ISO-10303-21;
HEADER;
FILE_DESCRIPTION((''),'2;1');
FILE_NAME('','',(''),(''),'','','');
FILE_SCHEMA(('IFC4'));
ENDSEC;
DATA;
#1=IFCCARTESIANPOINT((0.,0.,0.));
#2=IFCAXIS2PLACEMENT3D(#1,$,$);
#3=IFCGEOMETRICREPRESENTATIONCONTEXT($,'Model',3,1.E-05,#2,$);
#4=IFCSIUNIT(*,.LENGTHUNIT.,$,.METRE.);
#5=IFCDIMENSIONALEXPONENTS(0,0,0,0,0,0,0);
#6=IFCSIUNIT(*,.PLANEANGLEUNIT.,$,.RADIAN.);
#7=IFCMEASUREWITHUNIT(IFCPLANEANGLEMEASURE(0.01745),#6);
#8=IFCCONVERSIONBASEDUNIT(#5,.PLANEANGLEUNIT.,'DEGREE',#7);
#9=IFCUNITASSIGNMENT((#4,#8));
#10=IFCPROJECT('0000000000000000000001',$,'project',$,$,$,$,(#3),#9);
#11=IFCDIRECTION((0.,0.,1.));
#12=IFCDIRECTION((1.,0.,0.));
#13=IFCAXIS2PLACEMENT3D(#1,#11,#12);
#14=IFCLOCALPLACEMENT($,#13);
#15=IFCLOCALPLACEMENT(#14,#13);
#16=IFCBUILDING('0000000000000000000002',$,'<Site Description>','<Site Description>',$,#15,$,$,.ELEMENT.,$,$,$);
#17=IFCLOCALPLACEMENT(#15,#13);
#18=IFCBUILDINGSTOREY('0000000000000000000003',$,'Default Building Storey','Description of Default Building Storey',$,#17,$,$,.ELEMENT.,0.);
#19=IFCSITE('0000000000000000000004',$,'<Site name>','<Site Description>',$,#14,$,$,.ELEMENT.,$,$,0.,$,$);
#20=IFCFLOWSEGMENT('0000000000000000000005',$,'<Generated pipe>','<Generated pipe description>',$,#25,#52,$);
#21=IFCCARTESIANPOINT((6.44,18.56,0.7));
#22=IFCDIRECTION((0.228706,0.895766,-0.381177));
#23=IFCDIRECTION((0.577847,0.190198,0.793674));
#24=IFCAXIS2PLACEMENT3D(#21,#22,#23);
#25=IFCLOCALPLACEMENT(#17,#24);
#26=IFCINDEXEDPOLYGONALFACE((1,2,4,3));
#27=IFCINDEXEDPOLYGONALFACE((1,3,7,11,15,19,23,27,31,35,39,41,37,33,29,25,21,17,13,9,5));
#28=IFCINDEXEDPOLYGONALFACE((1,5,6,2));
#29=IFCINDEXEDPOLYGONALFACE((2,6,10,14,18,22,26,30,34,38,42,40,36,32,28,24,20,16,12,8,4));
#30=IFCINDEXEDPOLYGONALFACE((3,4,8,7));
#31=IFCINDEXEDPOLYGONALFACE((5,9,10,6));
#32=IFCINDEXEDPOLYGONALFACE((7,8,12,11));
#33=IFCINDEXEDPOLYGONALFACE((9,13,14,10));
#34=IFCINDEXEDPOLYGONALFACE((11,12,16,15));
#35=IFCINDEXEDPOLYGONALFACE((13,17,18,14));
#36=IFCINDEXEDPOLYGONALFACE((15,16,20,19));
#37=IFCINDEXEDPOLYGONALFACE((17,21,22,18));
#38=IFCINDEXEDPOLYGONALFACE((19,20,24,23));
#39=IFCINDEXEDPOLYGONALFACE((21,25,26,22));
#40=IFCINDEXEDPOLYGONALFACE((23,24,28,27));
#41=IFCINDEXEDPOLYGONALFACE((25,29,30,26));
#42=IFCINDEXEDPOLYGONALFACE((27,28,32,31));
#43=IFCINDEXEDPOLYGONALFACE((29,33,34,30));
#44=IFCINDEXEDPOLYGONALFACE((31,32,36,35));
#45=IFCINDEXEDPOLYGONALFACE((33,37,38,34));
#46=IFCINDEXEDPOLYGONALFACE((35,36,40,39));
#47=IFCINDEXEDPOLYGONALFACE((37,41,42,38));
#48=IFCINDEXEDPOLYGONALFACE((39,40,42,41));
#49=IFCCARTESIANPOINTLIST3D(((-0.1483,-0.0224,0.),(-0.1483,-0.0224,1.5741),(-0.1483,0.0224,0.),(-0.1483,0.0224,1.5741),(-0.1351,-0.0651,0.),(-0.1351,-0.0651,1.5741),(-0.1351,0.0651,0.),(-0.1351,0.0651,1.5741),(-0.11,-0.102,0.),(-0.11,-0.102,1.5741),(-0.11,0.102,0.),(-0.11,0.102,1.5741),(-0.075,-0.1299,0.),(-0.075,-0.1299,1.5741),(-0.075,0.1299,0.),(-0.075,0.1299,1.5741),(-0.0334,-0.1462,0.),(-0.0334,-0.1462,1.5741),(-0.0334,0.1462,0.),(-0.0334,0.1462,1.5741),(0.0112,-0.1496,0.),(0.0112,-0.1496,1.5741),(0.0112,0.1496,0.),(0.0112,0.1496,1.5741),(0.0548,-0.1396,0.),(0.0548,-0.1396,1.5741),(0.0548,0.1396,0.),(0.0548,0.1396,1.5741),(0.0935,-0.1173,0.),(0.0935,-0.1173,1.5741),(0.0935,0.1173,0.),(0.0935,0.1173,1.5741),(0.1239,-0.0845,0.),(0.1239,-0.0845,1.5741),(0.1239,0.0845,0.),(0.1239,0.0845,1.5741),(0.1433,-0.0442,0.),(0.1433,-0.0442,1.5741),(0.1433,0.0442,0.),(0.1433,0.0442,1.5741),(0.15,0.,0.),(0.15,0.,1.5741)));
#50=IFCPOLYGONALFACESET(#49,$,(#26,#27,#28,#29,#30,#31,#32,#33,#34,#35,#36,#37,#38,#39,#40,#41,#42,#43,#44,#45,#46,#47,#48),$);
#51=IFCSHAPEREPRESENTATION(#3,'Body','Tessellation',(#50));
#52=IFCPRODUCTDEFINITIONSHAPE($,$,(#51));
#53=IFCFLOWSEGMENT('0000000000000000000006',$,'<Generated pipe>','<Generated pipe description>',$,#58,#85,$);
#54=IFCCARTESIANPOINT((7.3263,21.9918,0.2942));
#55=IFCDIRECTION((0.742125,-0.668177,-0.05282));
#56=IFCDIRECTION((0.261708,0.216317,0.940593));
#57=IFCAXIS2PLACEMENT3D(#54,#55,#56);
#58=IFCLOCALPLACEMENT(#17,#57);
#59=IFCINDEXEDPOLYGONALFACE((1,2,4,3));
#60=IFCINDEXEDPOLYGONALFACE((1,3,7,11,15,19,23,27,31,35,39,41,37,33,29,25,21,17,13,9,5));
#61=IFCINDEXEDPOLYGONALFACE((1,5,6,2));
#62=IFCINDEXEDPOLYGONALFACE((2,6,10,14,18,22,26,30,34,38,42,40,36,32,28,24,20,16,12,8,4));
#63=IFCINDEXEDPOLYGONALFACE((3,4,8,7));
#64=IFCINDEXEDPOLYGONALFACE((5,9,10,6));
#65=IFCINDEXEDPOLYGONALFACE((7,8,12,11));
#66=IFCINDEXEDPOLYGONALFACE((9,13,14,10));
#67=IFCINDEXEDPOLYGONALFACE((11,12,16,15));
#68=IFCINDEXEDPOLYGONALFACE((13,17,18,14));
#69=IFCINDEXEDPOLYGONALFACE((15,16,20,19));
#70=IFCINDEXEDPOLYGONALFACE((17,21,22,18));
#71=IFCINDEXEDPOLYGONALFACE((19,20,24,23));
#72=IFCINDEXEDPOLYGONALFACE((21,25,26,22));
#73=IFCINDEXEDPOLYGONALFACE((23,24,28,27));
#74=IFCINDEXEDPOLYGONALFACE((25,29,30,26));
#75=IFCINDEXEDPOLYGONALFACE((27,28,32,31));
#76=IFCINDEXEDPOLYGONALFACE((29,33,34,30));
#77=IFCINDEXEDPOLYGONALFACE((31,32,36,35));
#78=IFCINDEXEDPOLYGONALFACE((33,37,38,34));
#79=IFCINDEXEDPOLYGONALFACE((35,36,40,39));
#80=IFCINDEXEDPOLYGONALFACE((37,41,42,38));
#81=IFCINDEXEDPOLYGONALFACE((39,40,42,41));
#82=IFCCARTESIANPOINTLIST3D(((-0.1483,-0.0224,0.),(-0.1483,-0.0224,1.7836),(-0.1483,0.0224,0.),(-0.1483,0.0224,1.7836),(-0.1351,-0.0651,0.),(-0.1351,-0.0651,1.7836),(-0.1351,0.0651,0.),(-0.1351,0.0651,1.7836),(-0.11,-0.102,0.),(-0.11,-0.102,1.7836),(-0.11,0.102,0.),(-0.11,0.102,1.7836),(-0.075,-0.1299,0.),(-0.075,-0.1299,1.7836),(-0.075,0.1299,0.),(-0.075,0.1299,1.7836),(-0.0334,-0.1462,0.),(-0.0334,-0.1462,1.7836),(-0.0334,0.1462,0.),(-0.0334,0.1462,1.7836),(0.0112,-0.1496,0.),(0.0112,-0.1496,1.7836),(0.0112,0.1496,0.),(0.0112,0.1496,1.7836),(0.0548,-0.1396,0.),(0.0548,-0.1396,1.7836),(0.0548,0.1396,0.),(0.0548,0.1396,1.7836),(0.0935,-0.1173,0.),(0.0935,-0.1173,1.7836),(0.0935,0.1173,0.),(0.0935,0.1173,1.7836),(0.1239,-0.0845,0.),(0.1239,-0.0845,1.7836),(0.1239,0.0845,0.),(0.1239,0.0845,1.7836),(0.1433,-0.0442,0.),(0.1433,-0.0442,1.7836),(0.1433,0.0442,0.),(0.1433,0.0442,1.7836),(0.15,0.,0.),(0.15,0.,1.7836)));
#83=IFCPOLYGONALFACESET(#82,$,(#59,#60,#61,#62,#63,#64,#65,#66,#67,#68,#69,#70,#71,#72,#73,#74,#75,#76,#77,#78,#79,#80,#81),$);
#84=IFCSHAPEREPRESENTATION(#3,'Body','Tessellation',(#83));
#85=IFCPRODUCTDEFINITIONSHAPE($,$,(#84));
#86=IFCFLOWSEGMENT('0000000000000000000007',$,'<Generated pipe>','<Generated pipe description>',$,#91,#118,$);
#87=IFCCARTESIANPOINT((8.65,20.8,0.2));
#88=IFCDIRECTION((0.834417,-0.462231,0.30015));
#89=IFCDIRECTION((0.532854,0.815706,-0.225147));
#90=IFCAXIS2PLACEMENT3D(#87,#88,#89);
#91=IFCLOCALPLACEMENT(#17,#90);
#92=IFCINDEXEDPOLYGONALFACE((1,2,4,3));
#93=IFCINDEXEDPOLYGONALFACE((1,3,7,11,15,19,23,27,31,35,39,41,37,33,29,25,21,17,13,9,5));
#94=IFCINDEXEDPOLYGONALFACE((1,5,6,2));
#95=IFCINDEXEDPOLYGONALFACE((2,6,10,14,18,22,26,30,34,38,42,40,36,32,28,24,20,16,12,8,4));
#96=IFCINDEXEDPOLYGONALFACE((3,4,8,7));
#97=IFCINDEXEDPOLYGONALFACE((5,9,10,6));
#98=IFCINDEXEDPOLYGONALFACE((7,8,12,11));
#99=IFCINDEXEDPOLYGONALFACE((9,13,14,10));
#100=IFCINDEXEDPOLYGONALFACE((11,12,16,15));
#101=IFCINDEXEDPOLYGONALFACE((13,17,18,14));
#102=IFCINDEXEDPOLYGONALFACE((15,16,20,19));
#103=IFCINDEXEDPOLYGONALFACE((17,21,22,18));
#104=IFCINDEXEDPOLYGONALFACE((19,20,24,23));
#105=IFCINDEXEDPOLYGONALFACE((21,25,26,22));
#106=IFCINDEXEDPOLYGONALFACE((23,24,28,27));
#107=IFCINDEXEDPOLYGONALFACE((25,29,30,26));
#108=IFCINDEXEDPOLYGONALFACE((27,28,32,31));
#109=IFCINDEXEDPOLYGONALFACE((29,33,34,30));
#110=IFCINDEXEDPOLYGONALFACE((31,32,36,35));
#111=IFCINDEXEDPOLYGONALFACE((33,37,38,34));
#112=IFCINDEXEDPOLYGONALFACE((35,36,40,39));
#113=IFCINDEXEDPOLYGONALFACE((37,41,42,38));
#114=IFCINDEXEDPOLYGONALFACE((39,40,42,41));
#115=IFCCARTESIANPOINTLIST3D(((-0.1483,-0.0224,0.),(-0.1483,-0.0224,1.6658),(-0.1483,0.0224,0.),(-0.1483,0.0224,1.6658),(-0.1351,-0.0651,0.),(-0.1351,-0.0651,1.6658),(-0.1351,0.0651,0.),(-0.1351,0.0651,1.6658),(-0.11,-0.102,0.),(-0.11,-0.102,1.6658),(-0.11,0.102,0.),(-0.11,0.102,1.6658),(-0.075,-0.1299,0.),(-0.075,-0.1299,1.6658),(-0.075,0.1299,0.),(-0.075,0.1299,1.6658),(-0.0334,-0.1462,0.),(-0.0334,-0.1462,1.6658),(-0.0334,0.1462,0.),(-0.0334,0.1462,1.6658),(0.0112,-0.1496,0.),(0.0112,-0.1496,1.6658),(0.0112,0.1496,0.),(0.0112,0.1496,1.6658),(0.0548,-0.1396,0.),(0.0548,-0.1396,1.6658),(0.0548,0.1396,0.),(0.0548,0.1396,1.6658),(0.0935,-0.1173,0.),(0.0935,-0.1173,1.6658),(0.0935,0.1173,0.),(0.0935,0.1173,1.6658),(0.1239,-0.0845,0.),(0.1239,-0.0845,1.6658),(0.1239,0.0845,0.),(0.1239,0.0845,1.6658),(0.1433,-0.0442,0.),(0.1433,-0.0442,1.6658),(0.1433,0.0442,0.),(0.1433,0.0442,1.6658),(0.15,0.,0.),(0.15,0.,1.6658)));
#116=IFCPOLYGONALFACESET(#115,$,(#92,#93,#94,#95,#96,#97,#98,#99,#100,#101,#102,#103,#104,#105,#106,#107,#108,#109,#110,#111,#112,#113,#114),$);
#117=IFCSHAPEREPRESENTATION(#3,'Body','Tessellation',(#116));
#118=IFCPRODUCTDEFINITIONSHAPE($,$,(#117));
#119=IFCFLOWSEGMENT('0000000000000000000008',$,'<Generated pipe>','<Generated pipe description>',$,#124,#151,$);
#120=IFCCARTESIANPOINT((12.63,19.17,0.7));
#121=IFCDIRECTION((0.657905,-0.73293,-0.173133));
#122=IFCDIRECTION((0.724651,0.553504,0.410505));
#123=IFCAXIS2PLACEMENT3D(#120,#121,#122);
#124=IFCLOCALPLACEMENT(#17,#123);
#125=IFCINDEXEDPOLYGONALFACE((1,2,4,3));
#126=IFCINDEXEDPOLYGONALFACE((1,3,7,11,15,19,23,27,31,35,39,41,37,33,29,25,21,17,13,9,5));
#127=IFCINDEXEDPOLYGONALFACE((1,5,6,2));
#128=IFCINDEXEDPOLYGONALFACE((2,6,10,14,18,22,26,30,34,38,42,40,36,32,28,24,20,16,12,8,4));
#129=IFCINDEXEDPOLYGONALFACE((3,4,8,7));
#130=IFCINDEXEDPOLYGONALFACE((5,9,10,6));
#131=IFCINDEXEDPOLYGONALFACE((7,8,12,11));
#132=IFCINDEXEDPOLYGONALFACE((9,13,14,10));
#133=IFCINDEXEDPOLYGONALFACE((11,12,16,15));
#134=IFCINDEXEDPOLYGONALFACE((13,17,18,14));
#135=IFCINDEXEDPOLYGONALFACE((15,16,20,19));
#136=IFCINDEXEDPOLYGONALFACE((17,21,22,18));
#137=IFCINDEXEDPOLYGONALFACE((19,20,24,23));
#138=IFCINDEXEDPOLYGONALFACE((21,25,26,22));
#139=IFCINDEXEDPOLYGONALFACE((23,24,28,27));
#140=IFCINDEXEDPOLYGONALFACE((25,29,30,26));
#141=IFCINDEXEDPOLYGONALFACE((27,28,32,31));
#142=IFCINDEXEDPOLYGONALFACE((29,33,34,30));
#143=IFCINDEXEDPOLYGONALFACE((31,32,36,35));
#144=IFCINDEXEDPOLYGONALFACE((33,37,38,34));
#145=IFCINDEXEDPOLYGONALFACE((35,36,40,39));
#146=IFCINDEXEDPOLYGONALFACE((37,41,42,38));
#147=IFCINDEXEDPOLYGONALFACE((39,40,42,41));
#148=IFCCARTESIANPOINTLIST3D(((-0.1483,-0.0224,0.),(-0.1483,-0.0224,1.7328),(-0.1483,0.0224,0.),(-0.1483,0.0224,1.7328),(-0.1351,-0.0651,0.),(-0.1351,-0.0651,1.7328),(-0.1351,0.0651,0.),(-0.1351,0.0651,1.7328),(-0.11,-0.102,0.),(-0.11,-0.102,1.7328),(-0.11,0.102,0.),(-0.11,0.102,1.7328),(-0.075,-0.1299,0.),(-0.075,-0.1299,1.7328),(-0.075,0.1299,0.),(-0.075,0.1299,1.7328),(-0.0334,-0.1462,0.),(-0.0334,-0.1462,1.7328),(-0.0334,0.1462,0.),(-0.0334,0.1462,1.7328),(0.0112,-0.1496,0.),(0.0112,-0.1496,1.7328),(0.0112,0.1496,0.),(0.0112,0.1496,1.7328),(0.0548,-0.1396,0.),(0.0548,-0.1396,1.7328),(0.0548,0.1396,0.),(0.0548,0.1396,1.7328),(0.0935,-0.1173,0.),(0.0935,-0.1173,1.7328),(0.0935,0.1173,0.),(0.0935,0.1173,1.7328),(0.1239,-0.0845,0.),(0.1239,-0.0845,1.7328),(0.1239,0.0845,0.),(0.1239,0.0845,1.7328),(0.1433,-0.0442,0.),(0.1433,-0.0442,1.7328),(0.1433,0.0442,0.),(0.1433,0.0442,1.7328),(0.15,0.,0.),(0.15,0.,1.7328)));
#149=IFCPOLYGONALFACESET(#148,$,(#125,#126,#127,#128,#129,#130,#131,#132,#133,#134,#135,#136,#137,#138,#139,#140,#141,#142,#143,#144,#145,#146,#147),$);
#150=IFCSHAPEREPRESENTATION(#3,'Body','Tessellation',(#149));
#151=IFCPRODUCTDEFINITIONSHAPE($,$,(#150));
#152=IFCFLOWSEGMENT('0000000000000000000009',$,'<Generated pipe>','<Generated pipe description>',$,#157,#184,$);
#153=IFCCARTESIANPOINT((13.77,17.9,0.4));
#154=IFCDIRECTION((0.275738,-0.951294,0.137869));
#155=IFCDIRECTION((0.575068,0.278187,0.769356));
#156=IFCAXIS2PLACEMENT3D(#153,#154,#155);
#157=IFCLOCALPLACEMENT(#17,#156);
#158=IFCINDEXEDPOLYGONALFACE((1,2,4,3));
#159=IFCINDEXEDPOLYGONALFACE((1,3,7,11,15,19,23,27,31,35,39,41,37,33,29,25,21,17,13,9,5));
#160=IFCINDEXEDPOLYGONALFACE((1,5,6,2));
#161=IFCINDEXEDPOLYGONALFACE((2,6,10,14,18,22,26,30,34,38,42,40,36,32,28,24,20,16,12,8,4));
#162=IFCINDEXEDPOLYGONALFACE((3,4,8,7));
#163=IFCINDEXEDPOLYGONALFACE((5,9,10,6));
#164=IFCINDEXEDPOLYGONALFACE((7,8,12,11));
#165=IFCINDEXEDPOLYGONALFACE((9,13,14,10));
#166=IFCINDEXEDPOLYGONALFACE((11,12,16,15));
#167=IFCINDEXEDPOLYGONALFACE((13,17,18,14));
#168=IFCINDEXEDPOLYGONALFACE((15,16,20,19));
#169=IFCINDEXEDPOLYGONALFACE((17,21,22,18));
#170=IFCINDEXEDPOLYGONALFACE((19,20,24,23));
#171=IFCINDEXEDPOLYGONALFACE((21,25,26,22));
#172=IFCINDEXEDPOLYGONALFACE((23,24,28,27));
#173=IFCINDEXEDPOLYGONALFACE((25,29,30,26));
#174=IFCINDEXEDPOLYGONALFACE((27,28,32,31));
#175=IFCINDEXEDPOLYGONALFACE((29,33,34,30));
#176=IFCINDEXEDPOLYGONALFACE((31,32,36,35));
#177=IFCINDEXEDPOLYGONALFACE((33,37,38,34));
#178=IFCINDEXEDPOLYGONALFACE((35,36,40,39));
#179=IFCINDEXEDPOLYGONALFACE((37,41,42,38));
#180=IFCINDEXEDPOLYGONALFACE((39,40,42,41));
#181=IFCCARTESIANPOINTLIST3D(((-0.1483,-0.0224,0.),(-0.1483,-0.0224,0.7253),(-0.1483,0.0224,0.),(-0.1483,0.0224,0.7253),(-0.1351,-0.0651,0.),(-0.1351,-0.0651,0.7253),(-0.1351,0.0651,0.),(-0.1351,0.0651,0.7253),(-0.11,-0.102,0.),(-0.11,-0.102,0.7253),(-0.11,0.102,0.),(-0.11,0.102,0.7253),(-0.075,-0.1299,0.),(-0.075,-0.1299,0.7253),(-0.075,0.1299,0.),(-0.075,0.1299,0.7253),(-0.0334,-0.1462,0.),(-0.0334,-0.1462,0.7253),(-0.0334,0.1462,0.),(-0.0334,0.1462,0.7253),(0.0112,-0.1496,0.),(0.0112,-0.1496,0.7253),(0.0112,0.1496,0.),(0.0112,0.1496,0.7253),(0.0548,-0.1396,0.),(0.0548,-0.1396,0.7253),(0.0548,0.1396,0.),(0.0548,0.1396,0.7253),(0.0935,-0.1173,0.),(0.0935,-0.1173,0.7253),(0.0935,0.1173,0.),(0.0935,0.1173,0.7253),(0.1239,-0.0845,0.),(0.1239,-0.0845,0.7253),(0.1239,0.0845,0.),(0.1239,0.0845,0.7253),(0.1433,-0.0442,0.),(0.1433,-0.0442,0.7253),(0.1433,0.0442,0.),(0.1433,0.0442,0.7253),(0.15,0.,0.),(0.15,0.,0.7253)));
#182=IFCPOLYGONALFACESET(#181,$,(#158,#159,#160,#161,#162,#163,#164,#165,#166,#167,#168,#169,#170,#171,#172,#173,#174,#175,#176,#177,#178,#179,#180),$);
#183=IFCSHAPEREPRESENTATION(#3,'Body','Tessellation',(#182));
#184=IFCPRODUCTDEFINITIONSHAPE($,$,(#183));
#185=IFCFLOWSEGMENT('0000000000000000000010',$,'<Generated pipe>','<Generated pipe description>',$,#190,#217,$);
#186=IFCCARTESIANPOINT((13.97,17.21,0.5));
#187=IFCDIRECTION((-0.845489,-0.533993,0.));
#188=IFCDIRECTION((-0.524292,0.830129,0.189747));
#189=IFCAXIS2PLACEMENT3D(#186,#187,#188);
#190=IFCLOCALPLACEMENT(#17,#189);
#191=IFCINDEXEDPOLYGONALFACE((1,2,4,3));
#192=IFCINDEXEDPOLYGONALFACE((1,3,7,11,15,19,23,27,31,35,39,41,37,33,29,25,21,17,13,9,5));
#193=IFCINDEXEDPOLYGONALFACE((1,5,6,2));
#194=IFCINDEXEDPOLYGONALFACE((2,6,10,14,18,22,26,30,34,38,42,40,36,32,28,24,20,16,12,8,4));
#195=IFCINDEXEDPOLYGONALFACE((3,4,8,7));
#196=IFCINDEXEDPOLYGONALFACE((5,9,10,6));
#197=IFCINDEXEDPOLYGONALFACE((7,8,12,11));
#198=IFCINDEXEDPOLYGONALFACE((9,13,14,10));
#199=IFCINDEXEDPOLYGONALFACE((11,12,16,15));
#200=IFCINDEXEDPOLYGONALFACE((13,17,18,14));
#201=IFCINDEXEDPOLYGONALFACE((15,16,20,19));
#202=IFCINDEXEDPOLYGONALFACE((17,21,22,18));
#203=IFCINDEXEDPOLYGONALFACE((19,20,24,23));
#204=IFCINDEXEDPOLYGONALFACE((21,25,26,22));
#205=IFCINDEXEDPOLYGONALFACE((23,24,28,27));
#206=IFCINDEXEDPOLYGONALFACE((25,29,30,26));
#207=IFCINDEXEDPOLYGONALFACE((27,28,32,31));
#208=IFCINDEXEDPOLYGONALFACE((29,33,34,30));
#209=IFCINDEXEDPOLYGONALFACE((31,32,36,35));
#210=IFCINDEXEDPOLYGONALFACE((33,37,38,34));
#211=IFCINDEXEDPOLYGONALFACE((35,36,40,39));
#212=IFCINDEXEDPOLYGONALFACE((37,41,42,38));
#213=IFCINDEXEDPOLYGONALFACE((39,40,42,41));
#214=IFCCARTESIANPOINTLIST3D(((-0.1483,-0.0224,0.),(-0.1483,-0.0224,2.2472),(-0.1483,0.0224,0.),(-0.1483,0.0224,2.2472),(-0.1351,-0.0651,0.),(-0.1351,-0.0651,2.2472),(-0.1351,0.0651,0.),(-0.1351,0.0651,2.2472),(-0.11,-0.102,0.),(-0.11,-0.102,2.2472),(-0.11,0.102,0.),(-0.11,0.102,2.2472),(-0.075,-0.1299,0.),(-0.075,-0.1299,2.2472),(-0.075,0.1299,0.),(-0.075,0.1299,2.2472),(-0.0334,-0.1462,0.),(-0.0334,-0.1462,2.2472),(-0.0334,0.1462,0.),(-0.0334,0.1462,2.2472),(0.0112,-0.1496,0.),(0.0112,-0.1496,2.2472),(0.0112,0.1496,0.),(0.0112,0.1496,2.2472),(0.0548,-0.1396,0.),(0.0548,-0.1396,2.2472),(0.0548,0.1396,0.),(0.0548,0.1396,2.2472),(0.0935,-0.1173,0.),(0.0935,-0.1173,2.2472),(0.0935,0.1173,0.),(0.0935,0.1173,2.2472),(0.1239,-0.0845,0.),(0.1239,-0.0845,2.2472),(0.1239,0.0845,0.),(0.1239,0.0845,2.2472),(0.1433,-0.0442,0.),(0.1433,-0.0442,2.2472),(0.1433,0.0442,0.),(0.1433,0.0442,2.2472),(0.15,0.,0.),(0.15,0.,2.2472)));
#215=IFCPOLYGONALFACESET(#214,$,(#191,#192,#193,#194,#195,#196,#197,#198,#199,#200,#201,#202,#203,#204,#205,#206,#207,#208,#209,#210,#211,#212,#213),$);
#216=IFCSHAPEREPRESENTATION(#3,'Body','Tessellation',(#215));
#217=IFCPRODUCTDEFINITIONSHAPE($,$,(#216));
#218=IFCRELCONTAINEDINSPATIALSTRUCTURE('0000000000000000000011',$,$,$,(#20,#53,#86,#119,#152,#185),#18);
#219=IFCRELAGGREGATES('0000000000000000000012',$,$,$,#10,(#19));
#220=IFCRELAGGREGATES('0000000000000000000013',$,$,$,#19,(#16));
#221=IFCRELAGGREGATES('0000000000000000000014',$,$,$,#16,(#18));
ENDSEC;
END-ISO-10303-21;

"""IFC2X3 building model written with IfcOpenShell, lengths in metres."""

from ifc_helpers import new_model, entity, si_unit, converted_unit, frame, origin, origin_with_axes, origin_2d_with_axis, place, context, project, spatial, circle, extrude, element, save


model = new_model("IFC2X3")

# Units and contexts
model_context = context("Model", 3, precision=1e-05, world=origin())
ifc_project = project(units=[si_unit("LENGTHUNIT", "METRE"), converted_unit("PLANEANGLEUNIT", "DEGREE", entity("IfcPlaneAngleMeasure", 0.01745), si_unit("PLANEANGLEUNIT", "RADIAN"), dimensions=[0, 0, 0, 0, 0, 0, 0])], contexts=[model_context])

# Site, building, storey
site_placement = place(None, origin_with_axes())
site = spatial("IfcSite", under=ifc_project, at=site_placement, Name="<Site name>", Description="<Site Description>", CompositionType="ELEMENT", RefElevation=0.0)
building_placement = place(site_placement, origin_with_axes())
building = spatial("IfcBuilding", under=site, at=building_placement, Name="<Site Description>", Description="<Site Description>", CompositionType="ELEMENT")
storey_placement = place(building_placement, origin_with_axes())
storey = spatial("IfcBuildingStorey", under=building, at=storey_placement, Name="Default Building Storey", Description="Description of Default Building Storey", CompositionType="ELEMENT", Elevation=0.0)

# Flow segments
flow_segment_1_placement = place(storey_placement, frame((6.44, 18.56, 0.7), z_axis=(0.228706, 0.895766, -0.381177), x_axis=(0.577847, 0.190198, 0.793674)))
element("IfcFlowSegment", 1, at=flow_segment_1_placement, inside=storey, Name="<Generated pipe>", Description="<Generated pipe description>", context=model_context, shape_type="SweptSolid", body=[
    extrude(circle(Radius=0.15, at=origin_2d_with_axis()), origin_with_axes(), (0.0, 0.0, 1.0), 1.5741),
])
flow_segment_2_placement = place(storey_placement, frame((7.3263, 21.9918, 0.2942), z_axis=(0.742125, -0.668177, -0.05282), x_axis=(0.261708, 0.216317, 0.940593)))
element("IfcFlowSegment", 2, at=flow_segment_2_placement, inside=storey, Name="<Generated pipe>", Description="<Generated pipe description>", context=model_context, shape_type="SweptSolid", body=[
    extrude(circle(Radius=0.15, at=origin_2d_with_axis()), origin_with_axes(), (0.0, 0.0, 1.0), 1.7836),
])
flow_segment_3_placement = place(storey_placement, frame((8.65, 20.8, 0.2), z_axis=(0.834417, -0.462231, 0.30015), x_axis=(0.532854, 0.815706, -0.225147)))
element("IfcFlowSegment", 3, at=flow_segment_3_placement, inside=storey, Name="<Generated pipe>", Description="<Generated pipe description>", context=model_context, shape_type="SweptSolid", body=[
    extrude(circle(Radius=0.15, at=origin_2d_with_axis()), origin_with_axes(), (0.0, 0.0, 1.0), 1.6658),
])
flow_segment_4_placement = place(storey_placement, frame((12.63, 19.17, 0.7), z_axis=(0.657905, -0.73293, -0.173133), x_axis=(0.724651, 0.553504, 0.410505)))
element("IfcFlowSegment", 4, at=flow_segment_4_placement, inside=storey, Name="<Generated pipe>", Description="<Generated pipe description>", context=model_context, shape_type="SweptSolid", body=[
    extrude(circle(Radius=0.15, at=origin_2d_with_axis()), origin_with_axes(), (0.0, 0.0, 1.0), 1.7328),
])
flow_segment_5_placement = place(storey_placement, frame((13.77, 17.9, 0.4), z_axis=(0.275738, -0.951294, 0.137869), x_axis=(0.575068, 0.278187, 0.769356)))
element("IfcFlowSegment", 5, at=flow_segment_5_placement, inside=storey, Name="<Generated pipe>", Description="<Generated pipe description>", context=model_context, shape_type="SweptSolid", body=[
    extrude(circle(Radius=0.15, at=origin_2d_with_axis()), origin_with_axes(), (0.0, 0.0, 1.0), 0.7253),
])
flow_segment_6_placement = place(storey_placement, frame((13.97, 17.21, 0.5), z_axis=(-0.845489, -0.533993, 0.0), x_axis=(-0.524292, 0.830129, 0.189747)))
element("IfcFlowSegment", 6, at=flow_segment_6_placement, inside=storey, Name="<Generated pipe>", Description="<Generated pipe description>", context=model_context, shape_type="SweptSolid", body=[
    extrude(circle(Radius=0.15, at=origin_2d_with_axis()), origin_with_axes(), (0.0, 0.0, 1.0), 2.2472),
])

save(model, "model.ifc")
